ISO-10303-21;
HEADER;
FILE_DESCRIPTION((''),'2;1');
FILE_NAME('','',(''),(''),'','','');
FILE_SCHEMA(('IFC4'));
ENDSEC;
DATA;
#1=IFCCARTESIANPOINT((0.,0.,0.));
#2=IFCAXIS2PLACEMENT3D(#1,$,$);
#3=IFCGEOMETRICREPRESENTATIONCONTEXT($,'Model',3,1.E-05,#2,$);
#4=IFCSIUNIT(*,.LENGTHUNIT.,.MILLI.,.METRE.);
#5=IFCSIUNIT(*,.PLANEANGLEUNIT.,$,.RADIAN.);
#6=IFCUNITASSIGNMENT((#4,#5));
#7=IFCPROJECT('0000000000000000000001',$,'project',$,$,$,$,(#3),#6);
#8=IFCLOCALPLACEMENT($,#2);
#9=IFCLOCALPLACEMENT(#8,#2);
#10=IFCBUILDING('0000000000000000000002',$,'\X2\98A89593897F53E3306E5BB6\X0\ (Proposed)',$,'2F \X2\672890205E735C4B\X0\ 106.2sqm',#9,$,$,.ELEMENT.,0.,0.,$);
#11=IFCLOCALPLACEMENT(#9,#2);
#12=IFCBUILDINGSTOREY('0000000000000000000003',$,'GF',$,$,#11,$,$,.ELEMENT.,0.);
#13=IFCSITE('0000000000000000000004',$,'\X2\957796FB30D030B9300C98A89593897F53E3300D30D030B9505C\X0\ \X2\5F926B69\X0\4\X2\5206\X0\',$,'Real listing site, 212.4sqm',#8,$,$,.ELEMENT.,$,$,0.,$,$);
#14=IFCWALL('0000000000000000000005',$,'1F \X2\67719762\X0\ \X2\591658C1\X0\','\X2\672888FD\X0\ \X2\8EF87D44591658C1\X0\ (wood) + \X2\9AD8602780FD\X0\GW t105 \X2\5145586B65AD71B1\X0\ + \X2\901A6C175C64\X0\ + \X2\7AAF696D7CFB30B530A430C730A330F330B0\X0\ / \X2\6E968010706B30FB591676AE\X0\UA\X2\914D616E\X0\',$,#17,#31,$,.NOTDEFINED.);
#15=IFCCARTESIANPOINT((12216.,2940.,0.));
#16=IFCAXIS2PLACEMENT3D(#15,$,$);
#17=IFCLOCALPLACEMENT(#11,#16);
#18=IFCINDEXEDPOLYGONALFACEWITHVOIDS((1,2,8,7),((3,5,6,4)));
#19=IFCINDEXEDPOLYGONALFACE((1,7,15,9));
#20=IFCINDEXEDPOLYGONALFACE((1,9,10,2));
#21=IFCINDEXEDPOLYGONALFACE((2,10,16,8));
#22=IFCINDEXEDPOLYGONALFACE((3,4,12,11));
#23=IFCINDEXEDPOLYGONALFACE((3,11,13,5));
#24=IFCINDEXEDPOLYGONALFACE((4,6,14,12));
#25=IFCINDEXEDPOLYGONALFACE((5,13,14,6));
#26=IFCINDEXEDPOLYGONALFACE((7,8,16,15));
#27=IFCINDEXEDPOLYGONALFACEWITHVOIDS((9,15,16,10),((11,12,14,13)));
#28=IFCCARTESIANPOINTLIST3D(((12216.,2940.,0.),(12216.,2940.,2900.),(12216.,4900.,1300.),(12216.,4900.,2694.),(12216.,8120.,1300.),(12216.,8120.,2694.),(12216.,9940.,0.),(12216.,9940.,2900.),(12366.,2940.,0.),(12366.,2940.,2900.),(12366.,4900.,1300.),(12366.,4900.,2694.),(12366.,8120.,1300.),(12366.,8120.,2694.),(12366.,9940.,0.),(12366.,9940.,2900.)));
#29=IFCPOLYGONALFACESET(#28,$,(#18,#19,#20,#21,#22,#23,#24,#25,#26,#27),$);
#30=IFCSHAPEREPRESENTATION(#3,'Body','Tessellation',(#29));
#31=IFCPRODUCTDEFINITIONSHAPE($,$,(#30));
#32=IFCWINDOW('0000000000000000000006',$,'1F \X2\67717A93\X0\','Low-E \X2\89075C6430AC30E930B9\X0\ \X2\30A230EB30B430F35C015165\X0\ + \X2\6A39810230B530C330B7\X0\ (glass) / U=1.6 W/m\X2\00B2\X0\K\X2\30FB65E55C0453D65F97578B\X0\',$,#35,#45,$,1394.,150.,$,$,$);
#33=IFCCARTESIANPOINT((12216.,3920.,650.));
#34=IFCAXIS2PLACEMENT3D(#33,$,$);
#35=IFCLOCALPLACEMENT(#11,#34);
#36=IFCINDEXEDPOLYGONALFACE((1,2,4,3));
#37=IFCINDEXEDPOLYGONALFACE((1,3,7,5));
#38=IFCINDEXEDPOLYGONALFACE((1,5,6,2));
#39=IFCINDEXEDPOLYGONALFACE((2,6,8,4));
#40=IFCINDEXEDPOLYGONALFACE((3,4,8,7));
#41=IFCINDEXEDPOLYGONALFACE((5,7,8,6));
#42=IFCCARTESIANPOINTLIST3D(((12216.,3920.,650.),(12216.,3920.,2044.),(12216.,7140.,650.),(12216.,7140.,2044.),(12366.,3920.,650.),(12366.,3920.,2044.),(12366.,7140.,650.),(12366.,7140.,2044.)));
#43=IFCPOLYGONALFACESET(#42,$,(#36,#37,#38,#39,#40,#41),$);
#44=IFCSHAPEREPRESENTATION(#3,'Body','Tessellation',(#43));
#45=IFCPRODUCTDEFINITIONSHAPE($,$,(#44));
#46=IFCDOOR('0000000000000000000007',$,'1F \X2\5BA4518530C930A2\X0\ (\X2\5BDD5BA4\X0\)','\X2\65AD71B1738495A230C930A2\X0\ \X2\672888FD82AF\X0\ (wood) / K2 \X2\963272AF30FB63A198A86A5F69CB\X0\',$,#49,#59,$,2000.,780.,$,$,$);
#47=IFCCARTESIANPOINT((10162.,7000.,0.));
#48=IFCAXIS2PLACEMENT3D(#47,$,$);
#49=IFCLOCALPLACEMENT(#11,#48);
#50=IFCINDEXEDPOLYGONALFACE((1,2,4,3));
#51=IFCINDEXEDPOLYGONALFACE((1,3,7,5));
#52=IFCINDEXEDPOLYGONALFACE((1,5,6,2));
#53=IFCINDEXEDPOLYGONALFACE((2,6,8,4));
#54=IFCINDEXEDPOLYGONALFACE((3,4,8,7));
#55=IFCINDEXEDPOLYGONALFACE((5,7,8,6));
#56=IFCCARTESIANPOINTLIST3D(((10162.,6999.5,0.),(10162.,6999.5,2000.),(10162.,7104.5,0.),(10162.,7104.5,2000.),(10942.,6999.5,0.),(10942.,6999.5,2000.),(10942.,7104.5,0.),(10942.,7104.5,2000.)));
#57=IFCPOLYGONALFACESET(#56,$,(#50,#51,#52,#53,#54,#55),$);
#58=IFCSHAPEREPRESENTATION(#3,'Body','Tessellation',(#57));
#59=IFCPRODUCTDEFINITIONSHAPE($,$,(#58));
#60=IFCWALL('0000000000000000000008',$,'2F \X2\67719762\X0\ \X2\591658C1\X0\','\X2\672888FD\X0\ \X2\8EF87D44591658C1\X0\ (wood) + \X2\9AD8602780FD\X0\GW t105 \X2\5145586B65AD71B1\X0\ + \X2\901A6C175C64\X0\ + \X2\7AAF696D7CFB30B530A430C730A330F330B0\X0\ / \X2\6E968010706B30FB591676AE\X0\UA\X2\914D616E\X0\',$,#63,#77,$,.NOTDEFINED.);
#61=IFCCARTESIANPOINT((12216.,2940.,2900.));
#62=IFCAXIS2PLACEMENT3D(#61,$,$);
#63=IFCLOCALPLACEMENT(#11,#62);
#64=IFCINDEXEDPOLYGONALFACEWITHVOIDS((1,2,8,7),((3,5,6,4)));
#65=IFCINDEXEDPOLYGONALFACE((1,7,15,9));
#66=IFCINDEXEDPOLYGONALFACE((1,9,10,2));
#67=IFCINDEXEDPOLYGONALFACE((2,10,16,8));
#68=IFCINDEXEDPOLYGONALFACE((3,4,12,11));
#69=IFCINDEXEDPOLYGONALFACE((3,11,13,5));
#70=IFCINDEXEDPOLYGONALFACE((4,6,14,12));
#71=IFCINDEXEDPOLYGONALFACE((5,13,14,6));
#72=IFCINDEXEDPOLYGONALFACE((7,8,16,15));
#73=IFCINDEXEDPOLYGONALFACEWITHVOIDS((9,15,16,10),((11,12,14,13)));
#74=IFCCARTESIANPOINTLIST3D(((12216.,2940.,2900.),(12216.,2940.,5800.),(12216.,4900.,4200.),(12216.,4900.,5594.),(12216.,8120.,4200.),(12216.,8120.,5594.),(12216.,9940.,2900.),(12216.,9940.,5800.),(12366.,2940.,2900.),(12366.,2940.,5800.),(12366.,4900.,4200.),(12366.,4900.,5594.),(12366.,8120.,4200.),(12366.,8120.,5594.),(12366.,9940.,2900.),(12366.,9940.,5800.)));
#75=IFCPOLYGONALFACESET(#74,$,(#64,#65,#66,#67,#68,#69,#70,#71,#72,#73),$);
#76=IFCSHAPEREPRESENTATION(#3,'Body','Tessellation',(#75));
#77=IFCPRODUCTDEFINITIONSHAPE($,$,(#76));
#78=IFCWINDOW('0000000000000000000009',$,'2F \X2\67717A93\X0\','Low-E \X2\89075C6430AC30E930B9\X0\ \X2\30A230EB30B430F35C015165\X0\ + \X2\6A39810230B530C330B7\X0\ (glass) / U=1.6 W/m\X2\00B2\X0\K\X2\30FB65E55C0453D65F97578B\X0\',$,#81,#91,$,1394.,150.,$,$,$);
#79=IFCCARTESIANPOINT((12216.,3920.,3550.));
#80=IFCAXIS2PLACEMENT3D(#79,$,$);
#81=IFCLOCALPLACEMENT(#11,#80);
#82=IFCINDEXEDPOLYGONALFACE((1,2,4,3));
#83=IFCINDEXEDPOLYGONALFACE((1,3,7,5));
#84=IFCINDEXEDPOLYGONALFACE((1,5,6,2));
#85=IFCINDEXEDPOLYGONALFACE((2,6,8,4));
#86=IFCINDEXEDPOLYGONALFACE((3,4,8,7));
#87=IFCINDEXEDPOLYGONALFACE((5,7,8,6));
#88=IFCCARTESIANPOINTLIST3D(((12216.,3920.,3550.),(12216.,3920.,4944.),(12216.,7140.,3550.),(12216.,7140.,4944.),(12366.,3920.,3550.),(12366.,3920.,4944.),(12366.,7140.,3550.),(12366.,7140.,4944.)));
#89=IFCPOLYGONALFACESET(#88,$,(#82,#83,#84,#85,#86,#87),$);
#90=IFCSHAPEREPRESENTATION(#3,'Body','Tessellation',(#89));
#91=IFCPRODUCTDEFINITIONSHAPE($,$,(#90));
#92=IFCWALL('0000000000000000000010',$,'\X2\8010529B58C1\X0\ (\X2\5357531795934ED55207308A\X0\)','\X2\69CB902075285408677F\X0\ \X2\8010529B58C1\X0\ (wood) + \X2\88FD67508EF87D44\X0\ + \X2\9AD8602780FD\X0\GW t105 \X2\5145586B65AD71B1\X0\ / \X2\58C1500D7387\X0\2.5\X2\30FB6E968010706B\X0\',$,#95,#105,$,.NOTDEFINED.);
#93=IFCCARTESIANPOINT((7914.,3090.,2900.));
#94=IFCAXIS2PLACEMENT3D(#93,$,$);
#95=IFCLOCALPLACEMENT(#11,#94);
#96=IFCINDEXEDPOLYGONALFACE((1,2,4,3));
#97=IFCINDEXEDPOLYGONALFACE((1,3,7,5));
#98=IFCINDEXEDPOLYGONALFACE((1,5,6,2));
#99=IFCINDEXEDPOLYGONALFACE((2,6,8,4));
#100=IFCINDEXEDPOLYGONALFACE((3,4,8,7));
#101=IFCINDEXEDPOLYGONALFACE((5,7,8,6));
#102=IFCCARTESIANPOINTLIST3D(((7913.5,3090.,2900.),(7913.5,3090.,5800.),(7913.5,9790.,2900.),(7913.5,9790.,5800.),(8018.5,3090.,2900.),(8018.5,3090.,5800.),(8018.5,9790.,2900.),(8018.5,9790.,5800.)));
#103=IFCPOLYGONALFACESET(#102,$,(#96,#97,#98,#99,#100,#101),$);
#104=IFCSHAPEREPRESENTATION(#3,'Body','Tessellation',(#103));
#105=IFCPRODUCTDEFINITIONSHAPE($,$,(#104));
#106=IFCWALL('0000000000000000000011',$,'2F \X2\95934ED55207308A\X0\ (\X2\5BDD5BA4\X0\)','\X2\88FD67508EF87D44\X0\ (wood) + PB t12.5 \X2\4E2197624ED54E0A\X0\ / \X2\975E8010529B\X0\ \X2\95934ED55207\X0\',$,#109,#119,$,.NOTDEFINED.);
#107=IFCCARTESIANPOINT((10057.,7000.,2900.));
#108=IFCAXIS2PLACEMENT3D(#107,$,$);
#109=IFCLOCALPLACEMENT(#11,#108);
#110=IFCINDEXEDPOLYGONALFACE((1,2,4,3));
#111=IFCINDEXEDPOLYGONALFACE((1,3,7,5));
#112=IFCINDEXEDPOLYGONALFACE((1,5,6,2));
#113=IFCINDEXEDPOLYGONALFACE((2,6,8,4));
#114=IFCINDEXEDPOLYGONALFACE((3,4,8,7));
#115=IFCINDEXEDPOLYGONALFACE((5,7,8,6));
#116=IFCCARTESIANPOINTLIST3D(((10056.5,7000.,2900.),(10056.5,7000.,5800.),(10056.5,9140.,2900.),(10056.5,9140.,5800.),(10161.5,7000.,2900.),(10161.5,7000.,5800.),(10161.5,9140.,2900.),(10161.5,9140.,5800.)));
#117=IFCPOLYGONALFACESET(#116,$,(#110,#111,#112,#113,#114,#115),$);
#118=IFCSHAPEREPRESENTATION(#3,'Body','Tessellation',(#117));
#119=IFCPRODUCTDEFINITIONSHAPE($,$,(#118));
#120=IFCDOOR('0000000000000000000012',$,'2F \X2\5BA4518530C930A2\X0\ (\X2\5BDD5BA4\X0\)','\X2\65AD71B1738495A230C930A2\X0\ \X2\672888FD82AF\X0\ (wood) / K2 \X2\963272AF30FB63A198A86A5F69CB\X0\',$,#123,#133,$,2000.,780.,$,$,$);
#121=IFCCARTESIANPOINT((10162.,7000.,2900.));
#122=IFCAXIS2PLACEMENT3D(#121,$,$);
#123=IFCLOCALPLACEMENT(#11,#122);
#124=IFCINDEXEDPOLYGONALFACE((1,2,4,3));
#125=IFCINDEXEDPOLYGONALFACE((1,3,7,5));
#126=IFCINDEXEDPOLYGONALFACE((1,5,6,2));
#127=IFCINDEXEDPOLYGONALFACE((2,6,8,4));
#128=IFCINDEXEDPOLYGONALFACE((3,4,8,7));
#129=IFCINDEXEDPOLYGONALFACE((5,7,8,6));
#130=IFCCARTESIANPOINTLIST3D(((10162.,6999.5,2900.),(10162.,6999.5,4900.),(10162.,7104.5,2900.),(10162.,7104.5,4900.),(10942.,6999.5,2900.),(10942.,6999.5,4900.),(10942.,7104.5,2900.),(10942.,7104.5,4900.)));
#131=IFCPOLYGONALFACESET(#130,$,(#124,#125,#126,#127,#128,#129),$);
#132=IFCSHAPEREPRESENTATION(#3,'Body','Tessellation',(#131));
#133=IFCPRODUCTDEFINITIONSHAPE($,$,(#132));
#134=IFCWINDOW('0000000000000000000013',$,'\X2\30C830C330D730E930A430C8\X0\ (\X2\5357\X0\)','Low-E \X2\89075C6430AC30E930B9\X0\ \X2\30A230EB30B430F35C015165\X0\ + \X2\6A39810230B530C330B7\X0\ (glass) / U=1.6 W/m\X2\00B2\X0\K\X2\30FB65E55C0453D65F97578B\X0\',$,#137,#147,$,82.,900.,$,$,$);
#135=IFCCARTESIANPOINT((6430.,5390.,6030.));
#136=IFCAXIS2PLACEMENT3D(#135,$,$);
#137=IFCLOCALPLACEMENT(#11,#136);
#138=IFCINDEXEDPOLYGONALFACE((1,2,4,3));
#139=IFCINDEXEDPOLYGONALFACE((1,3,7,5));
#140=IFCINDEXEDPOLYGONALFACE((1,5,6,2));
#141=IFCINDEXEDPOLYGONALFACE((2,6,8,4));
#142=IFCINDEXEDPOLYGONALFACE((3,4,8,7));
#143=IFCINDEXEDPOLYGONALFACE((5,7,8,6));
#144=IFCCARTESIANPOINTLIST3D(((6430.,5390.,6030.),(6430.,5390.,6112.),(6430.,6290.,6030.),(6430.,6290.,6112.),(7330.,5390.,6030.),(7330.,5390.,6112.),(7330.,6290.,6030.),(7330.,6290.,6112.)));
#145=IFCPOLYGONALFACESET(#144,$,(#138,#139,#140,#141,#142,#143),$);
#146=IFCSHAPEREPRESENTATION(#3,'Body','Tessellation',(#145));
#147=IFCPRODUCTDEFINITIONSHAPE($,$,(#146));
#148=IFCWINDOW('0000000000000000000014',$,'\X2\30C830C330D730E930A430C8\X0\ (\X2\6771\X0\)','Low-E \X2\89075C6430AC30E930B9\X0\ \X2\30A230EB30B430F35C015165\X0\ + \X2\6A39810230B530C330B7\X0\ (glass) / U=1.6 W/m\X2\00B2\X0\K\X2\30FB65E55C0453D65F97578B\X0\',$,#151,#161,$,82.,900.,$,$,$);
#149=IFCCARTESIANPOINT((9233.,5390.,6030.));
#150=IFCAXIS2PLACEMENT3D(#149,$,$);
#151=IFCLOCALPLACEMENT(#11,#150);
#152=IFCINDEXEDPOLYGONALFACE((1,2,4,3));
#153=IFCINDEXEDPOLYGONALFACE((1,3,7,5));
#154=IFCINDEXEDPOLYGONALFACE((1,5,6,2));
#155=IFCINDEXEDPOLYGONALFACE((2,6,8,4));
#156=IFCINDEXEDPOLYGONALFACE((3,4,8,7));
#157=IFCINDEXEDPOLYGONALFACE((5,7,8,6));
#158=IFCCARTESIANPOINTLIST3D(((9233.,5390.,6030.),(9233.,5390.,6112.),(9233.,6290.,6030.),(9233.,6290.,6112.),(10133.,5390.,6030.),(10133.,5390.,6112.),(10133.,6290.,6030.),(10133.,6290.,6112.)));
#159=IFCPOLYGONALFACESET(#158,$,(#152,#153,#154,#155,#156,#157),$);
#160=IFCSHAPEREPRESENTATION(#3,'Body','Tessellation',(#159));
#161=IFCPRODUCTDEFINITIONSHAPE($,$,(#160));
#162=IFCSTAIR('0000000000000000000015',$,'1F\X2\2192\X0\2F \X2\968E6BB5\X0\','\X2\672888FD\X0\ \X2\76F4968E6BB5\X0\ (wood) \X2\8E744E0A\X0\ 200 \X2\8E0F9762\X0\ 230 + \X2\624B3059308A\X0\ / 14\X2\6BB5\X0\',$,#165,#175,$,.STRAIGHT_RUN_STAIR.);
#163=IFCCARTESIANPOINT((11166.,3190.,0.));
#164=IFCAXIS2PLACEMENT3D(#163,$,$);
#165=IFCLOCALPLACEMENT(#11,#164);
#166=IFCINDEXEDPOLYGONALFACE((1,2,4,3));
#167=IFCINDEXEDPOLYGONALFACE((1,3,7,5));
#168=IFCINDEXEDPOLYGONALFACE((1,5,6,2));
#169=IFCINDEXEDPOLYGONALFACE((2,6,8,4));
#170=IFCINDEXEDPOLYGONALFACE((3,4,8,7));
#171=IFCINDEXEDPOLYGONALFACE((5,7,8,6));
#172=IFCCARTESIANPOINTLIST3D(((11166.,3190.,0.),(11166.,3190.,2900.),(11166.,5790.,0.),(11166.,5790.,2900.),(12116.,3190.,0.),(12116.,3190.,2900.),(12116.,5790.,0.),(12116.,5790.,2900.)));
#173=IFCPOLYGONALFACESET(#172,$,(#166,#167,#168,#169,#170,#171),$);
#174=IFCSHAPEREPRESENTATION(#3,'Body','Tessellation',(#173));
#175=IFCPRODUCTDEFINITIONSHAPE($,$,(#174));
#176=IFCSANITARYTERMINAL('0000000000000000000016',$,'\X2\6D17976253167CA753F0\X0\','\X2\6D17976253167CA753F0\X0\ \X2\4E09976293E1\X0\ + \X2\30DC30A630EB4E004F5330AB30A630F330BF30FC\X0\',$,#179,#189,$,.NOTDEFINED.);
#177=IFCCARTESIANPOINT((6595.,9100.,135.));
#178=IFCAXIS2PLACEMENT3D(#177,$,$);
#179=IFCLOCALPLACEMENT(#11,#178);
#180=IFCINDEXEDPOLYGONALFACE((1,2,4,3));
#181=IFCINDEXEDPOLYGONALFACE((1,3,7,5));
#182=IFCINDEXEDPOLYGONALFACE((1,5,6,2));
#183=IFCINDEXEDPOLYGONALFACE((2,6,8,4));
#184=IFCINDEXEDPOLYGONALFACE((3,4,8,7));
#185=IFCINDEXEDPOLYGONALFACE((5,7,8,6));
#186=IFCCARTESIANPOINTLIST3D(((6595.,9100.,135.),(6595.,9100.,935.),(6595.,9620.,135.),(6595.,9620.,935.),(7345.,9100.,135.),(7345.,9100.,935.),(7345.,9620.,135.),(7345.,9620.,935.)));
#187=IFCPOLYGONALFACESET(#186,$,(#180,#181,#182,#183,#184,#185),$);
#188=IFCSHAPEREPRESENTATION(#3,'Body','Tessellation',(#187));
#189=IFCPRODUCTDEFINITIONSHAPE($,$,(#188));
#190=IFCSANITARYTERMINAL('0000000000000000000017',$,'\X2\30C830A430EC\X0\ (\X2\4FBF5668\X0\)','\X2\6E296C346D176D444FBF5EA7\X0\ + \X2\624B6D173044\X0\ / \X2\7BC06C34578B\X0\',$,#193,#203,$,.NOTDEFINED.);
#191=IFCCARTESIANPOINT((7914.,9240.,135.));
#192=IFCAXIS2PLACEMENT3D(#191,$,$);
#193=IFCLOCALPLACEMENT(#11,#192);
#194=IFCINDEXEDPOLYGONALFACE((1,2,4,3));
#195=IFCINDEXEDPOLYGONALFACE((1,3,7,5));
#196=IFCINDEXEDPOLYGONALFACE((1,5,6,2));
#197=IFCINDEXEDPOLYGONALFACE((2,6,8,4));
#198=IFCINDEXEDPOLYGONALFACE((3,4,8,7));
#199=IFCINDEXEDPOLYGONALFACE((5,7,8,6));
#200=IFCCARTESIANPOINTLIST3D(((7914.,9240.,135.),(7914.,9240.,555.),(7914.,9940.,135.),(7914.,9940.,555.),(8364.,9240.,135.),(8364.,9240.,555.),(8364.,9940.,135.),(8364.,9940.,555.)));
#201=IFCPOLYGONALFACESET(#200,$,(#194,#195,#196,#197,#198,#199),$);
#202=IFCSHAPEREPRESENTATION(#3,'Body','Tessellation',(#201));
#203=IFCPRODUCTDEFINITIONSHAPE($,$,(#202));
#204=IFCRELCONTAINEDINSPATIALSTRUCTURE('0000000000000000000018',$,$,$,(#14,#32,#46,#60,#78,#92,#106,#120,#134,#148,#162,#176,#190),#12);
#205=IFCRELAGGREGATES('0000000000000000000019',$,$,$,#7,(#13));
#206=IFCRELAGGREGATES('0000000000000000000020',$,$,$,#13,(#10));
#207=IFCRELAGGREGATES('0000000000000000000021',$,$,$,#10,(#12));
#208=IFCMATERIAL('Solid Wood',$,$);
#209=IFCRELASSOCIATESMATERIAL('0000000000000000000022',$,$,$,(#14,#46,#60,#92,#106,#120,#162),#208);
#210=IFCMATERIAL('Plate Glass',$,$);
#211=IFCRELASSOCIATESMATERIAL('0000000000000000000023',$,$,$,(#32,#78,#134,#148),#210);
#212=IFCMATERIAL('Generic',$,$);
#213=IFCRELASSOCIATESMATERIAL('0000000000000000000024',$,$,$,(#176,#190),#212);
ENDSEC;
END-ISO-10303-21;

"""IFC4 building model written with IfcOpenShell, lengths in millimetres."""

from ifc_helpers import new_model, si_unit, frame, frame_2d, origin, place, context, project, spatial, rectangle, extrude, material, element, fill, save


model = new_model("IFC4")

# Units and contexts
model_context = context("Model", 3, precision=1e-05, world=origin())
ifc_project = project(units=[si_unit("LENGTHUNIT", "METRE", prefix="MILLI"), si_unit("PLANEANGLEUNIT", "RADIAN")], contexts=[model_context])

# Site, building, storey
site_placement = place(None, origin())
site = spatial("IfcSite", under=ifc_project, at=site_placement, Name="長電バス「風間西口」バス停 徒歩4分", ObjectType="Real listing site, 212.4sqm", CompositionType="ELEMENT", RefElevation=0.0)
building_placement = place(site_placement, origin())
building = spatial("IfcBuilding", under=site, at=building_placement, Name="風間西口の家 (Proposed)", ObjectType="2F 木造平屋 106.2sqm", CompositionType="ELEMENT", ElevationOfRefHeight=0.0, ElevationOfTerrain=0.0)
storey_placement = place(building_placement, origin())
storey = spatial("IfcBuildingStorey", under=building, at=storey_placement, Name="GF", CompositionType="ELEMENT", Elevation=0.0)

# Wall, opening, window
ifc_material_1 = material(Name="Solid Wood")
wall_1_placement = place(storey_placement, frame((12216.0, 2940.0, 0.0)))
wall_1 = element("IfcWall", 1, at=wall_1_placement, inside=storey, material=ifc_material_1, Name="1F 東面 外壁", Description="木製 軸組外壁 (wood) + 高性能GW t105 充填断熱 + 通気層 + 窯業系サイディング / 準耐火・外皮UA配慮", PredefinedType="NOTDEFINED", context=model_context, shape_type="SweptSolid", body=[
    extrude(rectangle(XDim=150.0, YDim=7000.0, at=frame_2d((75.0, 3500.0))), frame((12216.0, 2940.0, 0.0)), (0.0, 0.0, 1.0), 2900.0),
])
opening_1_placement = place(storey_placement, frame((12216.0, 3920.0, 650.0)))
opening_1 = element("IfcOpeningElement", 2, at=opening_1_placement, cuts=wall_1, PredefinedType="NOTDEFINED", context=model_context, shape_type="SweptSolid", body=[
    extrude(rectangle(XDim=150.0, YDim=3220.0, at=frame_2d((75.0, 1610.0))), frame((12216.0, 3920.0, 650.0)), (0.0, 0.0, 1.0), 1394.0),
])
ifc_material_2 = material(Name="Plate Glass")
window_1_placement = place(storey_placement, frame((12216.0, 3920.0, 650.0)))
window_1 = element("IfcWindow", 3, at=window_1_placement, inside=storey, material=ifc_material_2, Name="1F 東窓", Description="Low-E 複層ガラス アルゴン封入 + 樹脂サッシ (glass) / U=1.6 W/m²K・日射取得型", OverallHeight=1394.0, OverallWidth=150.0, context=model_context, shape_type="SweptSolid", body=[
    extrude(rectangle(XDim=150.0, YDim=3220.0, at=frame_2d((75.0, 1610.0))), frame((12216.0, 3920.0, 650.0)), (0.0, 0.0, 1.0), 1394.0),
])
fill(opening_1, window_1)

# Door
door_1_placement = place(storey_placement, frame((10162.0, 7000.0, 0.0)))
element("IfcDoor", 4, at=door_1_placement, inside=storey, material=ifc_material_1, Name="1F 室内ドア (寝室)", Description="断熱玄関ドア 木製芯 (wood) / K2 防犯・採風機構", OverallHeight=2000.0, OverallWidth=780.0, context=model_context, shape_type="SweptSolid", body=[
    extrude(rectangle(XDim=780.0, YDim=105.0, at=frame_2d((390.0, 52.0))), frame((10162.0, 7000.0, 0.0)), (0.0, 0.0, 1.0), 2000.0),
])

# Wall, opening, window
wall_2_placement = place(storey_placement, frame((12216.0, 2940.0, 2900.0)))
wall_2 = element("IfcWall", 5, at=wall_2_placement, inside=storey, material=ifc_material_1, Name="2F 東面 外壁", Description="木製 軸組外壁 (wood) + 高性能GW t105 充填断熱 + 通気層 + 窯業系サイディング / 準耐火・外皮UA配慮", PredefinedType="NOTDEFINED", context=model_context, shape_type="SweptSolid", body=[
    extrude(rectangle(XDim=150.0, YDim=7000.0, at=frame_2d((75.0, 3500.0))), frame((12216.0, 2940.0, 2900.0)), (0.0, 0.0, 1.0), 2900.0),
])
opening_2_placement = place(storey_placement, frame((12216.0, 3920.0, 3550.0)))
opening_2 = element("IfcOpeningElement", 6, at=opening_2_placement, cuts=wall_2, PredefinedType="NOTDEFINED", context=model_context, shape_type="SweptSolid", body=[
    extrude(rectangle(XDim=150.0, YDim=3220.0, at=frame_2d((75.0, 1610.0))), frame((12216.0, 3920.0, 3550.0)), (0.0, 0.0, 1.0), 1394.0),
])
window_2_placement = place(storey_placement, frame((12216.0, 3920.0, 3550.0)))
window_2 = element("IfcWindow", 7, at=window_2_placement, inside=storey, material=ifc_material_2, Name="2F 東窓", Description="Low-E 複層ガラス アルゴン封入 + 樹脂サッシ (glass) / U=1.6 W/m²K・日射取得型", OverallHeight=1394.0, OverallWidth=150.0, context=model_context, shape_type="SweptSolid", body=[
    extrude(rectangle(XDim=150.0, YDim=3220.0, at=frame_2d((75.0, 1610.0))), frame((12216.0, 3920.0, 3550.0)), (0.0, 0.0, 1.0), 1394.0),
])
fill(opening_2, window_2)

# Walls
wall_3_placement = place(storey_placement, frame((7914.0, 3090.0, 2900.0)))
element("IfcWall", 8, at=wall_3_placement, inside=storey, material=ifc_material_1, Name="耐力壁 (南北間仕切り)", Description="構造用合板 耐力壁 (wood) + 製材軸組 + 高性能GW t105 充填断熱 / 壁倍率2.5・準耐火", PredefinedType="NOTDEFINED", context=model_context, shape_type="SweptSolid", body=[
    extrude(rectangle(XDim=105.0, YDim=6700.0, at=frame_2d((52.0, 3350.0))), frame((7914.0, 3090.0, 2900.0)), (0.0, 0.0, 1.0), 2900.0),
])
wall_4_placement = place(storey_placement, frame((10057.0, 7000.0, 2900.0)))
element("IfcWall", 9, at=wall_4_placement, inside=storey, material=ifc_material_1, Name="2F 間仕切り (寝室)", Description="製材軸組 (wood) + PB t12.5 両面仕上 / 非耐力 間仕切", PredefinedType="NOTDEFINED", context=model_context, shape_type="SweptSolid", body=[
    extrude(rectangle(XDim=105.0, YDim=2140.0, at=frame_2d((52.0, 1070.0))), frame((10057.0, 7000.0, 2900.0)), (0.0, 0.0, 1.0), 2900.0),
])

# Door
door_2_placement = place(storey_placement, frame((10162.0, 7000.0, 2900.0)))
element("IfcDoor", 10, at=door_2_placement, inside=storey, material=ifc_material_1, Name="2F 室内ドア (寝室)", Description="断熱玄関ドア 木製芯 (wood) / K2 防犯・採風機構", OverallHeight=2000.0, OverallWidth=780.0, context=model_context, shape_type="SweptSolid", body=[
    extrude(rectangle(XDim=780.0, YDim=105.0, at=frame_2d((390.0, 52.0))), frame((10162.0, 7000.0, 2900.0)), (0.0, 0.0, 1.0), 2000.0),
])

# Windows
window_3_placement = place(storey_placement, frame((6430.0, 5390.0, 6030.0)))
element("IfcWindow", 11, at=window_3_placement, inside=storey, material=ifc_material_2, Name="トップライト (南)", Description="Low-E 複層ガラス アルゴン封入 + 樹脂サッシ (glass) / U=1.6 W/m²K・日射取得型", OverallHeight=82.0, OverallWidth=900.0, context=model_context, shape_type="SweptSolid", body=[
    extrude(rectangle(XDim=900.0, YDim=900.0, at=frame_2d((450.0, 450.0))), frame((6430.0, 5390.0, 6030.0)), (0.0, 0.0, 1.0), 82.0),
])
window_4_placement = place(storey_placement, frame((9233.0, 5390.0, 6030.0)))
element("IfcWindow", 12, at=window_4_placement, inside=storey, material=ifc_material_2, Name="トップライト (東)", Description="Low-E 複層ガラス アルゴン封入 + 樹脂サッシ (glass) / U=1.6 W/m²K・日射取得型", OverallHeight=82.0, OverallWidth=900.0, context=model_context, shape_type="SweptSolid", body=[
    extrude(rectangle(XDim=900.0, YDim=900.0, at=frame_2d((450.0, 450.0))), frame((9233.0, 5390.0, 6030.0)), (0.0, 0.0, 1.0), 82.0),
])

# Stair
stair_placement = place(storey_placement, frame((11166.0, 3190.0, 0.0)))
element("IfcStair", 13, at=stair_placement, inside=storey, material=ifc_material_1, Name="1F→2F 階段", Description="木製 直階段 (wood) 蹴上 200 踏面 230 + 手すり / 14段", PredefinedType="STRAIGHT_RUN_STAIR", context=model_context, shape_type="SweptSolid", body=[
    extrude(rectangle(XDim=950.0, YDim=2600.0, at=frame_2d((475.0, 1300.0))), frame((11166.0, 3190.0, 0.0)), (0.0, 0.0, 1.0), 2900.0),
])

# Sanitary terminals
ifc_material_3 = material(Name="Generic")
sanitary_terminal_1_placement = place(storey_placement, frame((6595.0, 9100.0, 135.0)))
element("IfcSanitaryTerminal", 14, at=sanitary_terminal_1_placement, inside=storey, material=ifc_material_3, Name="洗面化粧台", Description="洗面化粧台 三面鏡 + ボウル一体カウンター", PredefinedType="NOTDEFINED", context=model_context, shape_type="SweptSolid", body=[
    extrude(rectangle(XDim=750.0, YDim=520.0, at=frame_2d((375.0, 260.0))), frame((6595.0, 9100.0, 135.0)), (0.0, 0.0, 1.0), 800.0),
])
sanitary_terminal_2_placement = place(storey_placement, frame((7914.0, 9240.0, 135.0)))
element("IfcSanitaryTerminal", 15, at=sanitary_terminal_2_placement, inside=storey, material=ifc_material_3, Name="トイレ (便器)", Description="温水洗浄便座 + 手洗い / 節水型", PredefinedType="NOTDEFINED", context=model_context, shape_type="SweptSolid", body=[
    extrude(rectangle(XDim=450.0, YDim=700.0, at=frame_2d((225.0, 350.0))), frame((7914.0, 9240.0, 135.0)), (0.0, 0.0, 1.0), 420.0),
])

save(model, "model.ifc")
